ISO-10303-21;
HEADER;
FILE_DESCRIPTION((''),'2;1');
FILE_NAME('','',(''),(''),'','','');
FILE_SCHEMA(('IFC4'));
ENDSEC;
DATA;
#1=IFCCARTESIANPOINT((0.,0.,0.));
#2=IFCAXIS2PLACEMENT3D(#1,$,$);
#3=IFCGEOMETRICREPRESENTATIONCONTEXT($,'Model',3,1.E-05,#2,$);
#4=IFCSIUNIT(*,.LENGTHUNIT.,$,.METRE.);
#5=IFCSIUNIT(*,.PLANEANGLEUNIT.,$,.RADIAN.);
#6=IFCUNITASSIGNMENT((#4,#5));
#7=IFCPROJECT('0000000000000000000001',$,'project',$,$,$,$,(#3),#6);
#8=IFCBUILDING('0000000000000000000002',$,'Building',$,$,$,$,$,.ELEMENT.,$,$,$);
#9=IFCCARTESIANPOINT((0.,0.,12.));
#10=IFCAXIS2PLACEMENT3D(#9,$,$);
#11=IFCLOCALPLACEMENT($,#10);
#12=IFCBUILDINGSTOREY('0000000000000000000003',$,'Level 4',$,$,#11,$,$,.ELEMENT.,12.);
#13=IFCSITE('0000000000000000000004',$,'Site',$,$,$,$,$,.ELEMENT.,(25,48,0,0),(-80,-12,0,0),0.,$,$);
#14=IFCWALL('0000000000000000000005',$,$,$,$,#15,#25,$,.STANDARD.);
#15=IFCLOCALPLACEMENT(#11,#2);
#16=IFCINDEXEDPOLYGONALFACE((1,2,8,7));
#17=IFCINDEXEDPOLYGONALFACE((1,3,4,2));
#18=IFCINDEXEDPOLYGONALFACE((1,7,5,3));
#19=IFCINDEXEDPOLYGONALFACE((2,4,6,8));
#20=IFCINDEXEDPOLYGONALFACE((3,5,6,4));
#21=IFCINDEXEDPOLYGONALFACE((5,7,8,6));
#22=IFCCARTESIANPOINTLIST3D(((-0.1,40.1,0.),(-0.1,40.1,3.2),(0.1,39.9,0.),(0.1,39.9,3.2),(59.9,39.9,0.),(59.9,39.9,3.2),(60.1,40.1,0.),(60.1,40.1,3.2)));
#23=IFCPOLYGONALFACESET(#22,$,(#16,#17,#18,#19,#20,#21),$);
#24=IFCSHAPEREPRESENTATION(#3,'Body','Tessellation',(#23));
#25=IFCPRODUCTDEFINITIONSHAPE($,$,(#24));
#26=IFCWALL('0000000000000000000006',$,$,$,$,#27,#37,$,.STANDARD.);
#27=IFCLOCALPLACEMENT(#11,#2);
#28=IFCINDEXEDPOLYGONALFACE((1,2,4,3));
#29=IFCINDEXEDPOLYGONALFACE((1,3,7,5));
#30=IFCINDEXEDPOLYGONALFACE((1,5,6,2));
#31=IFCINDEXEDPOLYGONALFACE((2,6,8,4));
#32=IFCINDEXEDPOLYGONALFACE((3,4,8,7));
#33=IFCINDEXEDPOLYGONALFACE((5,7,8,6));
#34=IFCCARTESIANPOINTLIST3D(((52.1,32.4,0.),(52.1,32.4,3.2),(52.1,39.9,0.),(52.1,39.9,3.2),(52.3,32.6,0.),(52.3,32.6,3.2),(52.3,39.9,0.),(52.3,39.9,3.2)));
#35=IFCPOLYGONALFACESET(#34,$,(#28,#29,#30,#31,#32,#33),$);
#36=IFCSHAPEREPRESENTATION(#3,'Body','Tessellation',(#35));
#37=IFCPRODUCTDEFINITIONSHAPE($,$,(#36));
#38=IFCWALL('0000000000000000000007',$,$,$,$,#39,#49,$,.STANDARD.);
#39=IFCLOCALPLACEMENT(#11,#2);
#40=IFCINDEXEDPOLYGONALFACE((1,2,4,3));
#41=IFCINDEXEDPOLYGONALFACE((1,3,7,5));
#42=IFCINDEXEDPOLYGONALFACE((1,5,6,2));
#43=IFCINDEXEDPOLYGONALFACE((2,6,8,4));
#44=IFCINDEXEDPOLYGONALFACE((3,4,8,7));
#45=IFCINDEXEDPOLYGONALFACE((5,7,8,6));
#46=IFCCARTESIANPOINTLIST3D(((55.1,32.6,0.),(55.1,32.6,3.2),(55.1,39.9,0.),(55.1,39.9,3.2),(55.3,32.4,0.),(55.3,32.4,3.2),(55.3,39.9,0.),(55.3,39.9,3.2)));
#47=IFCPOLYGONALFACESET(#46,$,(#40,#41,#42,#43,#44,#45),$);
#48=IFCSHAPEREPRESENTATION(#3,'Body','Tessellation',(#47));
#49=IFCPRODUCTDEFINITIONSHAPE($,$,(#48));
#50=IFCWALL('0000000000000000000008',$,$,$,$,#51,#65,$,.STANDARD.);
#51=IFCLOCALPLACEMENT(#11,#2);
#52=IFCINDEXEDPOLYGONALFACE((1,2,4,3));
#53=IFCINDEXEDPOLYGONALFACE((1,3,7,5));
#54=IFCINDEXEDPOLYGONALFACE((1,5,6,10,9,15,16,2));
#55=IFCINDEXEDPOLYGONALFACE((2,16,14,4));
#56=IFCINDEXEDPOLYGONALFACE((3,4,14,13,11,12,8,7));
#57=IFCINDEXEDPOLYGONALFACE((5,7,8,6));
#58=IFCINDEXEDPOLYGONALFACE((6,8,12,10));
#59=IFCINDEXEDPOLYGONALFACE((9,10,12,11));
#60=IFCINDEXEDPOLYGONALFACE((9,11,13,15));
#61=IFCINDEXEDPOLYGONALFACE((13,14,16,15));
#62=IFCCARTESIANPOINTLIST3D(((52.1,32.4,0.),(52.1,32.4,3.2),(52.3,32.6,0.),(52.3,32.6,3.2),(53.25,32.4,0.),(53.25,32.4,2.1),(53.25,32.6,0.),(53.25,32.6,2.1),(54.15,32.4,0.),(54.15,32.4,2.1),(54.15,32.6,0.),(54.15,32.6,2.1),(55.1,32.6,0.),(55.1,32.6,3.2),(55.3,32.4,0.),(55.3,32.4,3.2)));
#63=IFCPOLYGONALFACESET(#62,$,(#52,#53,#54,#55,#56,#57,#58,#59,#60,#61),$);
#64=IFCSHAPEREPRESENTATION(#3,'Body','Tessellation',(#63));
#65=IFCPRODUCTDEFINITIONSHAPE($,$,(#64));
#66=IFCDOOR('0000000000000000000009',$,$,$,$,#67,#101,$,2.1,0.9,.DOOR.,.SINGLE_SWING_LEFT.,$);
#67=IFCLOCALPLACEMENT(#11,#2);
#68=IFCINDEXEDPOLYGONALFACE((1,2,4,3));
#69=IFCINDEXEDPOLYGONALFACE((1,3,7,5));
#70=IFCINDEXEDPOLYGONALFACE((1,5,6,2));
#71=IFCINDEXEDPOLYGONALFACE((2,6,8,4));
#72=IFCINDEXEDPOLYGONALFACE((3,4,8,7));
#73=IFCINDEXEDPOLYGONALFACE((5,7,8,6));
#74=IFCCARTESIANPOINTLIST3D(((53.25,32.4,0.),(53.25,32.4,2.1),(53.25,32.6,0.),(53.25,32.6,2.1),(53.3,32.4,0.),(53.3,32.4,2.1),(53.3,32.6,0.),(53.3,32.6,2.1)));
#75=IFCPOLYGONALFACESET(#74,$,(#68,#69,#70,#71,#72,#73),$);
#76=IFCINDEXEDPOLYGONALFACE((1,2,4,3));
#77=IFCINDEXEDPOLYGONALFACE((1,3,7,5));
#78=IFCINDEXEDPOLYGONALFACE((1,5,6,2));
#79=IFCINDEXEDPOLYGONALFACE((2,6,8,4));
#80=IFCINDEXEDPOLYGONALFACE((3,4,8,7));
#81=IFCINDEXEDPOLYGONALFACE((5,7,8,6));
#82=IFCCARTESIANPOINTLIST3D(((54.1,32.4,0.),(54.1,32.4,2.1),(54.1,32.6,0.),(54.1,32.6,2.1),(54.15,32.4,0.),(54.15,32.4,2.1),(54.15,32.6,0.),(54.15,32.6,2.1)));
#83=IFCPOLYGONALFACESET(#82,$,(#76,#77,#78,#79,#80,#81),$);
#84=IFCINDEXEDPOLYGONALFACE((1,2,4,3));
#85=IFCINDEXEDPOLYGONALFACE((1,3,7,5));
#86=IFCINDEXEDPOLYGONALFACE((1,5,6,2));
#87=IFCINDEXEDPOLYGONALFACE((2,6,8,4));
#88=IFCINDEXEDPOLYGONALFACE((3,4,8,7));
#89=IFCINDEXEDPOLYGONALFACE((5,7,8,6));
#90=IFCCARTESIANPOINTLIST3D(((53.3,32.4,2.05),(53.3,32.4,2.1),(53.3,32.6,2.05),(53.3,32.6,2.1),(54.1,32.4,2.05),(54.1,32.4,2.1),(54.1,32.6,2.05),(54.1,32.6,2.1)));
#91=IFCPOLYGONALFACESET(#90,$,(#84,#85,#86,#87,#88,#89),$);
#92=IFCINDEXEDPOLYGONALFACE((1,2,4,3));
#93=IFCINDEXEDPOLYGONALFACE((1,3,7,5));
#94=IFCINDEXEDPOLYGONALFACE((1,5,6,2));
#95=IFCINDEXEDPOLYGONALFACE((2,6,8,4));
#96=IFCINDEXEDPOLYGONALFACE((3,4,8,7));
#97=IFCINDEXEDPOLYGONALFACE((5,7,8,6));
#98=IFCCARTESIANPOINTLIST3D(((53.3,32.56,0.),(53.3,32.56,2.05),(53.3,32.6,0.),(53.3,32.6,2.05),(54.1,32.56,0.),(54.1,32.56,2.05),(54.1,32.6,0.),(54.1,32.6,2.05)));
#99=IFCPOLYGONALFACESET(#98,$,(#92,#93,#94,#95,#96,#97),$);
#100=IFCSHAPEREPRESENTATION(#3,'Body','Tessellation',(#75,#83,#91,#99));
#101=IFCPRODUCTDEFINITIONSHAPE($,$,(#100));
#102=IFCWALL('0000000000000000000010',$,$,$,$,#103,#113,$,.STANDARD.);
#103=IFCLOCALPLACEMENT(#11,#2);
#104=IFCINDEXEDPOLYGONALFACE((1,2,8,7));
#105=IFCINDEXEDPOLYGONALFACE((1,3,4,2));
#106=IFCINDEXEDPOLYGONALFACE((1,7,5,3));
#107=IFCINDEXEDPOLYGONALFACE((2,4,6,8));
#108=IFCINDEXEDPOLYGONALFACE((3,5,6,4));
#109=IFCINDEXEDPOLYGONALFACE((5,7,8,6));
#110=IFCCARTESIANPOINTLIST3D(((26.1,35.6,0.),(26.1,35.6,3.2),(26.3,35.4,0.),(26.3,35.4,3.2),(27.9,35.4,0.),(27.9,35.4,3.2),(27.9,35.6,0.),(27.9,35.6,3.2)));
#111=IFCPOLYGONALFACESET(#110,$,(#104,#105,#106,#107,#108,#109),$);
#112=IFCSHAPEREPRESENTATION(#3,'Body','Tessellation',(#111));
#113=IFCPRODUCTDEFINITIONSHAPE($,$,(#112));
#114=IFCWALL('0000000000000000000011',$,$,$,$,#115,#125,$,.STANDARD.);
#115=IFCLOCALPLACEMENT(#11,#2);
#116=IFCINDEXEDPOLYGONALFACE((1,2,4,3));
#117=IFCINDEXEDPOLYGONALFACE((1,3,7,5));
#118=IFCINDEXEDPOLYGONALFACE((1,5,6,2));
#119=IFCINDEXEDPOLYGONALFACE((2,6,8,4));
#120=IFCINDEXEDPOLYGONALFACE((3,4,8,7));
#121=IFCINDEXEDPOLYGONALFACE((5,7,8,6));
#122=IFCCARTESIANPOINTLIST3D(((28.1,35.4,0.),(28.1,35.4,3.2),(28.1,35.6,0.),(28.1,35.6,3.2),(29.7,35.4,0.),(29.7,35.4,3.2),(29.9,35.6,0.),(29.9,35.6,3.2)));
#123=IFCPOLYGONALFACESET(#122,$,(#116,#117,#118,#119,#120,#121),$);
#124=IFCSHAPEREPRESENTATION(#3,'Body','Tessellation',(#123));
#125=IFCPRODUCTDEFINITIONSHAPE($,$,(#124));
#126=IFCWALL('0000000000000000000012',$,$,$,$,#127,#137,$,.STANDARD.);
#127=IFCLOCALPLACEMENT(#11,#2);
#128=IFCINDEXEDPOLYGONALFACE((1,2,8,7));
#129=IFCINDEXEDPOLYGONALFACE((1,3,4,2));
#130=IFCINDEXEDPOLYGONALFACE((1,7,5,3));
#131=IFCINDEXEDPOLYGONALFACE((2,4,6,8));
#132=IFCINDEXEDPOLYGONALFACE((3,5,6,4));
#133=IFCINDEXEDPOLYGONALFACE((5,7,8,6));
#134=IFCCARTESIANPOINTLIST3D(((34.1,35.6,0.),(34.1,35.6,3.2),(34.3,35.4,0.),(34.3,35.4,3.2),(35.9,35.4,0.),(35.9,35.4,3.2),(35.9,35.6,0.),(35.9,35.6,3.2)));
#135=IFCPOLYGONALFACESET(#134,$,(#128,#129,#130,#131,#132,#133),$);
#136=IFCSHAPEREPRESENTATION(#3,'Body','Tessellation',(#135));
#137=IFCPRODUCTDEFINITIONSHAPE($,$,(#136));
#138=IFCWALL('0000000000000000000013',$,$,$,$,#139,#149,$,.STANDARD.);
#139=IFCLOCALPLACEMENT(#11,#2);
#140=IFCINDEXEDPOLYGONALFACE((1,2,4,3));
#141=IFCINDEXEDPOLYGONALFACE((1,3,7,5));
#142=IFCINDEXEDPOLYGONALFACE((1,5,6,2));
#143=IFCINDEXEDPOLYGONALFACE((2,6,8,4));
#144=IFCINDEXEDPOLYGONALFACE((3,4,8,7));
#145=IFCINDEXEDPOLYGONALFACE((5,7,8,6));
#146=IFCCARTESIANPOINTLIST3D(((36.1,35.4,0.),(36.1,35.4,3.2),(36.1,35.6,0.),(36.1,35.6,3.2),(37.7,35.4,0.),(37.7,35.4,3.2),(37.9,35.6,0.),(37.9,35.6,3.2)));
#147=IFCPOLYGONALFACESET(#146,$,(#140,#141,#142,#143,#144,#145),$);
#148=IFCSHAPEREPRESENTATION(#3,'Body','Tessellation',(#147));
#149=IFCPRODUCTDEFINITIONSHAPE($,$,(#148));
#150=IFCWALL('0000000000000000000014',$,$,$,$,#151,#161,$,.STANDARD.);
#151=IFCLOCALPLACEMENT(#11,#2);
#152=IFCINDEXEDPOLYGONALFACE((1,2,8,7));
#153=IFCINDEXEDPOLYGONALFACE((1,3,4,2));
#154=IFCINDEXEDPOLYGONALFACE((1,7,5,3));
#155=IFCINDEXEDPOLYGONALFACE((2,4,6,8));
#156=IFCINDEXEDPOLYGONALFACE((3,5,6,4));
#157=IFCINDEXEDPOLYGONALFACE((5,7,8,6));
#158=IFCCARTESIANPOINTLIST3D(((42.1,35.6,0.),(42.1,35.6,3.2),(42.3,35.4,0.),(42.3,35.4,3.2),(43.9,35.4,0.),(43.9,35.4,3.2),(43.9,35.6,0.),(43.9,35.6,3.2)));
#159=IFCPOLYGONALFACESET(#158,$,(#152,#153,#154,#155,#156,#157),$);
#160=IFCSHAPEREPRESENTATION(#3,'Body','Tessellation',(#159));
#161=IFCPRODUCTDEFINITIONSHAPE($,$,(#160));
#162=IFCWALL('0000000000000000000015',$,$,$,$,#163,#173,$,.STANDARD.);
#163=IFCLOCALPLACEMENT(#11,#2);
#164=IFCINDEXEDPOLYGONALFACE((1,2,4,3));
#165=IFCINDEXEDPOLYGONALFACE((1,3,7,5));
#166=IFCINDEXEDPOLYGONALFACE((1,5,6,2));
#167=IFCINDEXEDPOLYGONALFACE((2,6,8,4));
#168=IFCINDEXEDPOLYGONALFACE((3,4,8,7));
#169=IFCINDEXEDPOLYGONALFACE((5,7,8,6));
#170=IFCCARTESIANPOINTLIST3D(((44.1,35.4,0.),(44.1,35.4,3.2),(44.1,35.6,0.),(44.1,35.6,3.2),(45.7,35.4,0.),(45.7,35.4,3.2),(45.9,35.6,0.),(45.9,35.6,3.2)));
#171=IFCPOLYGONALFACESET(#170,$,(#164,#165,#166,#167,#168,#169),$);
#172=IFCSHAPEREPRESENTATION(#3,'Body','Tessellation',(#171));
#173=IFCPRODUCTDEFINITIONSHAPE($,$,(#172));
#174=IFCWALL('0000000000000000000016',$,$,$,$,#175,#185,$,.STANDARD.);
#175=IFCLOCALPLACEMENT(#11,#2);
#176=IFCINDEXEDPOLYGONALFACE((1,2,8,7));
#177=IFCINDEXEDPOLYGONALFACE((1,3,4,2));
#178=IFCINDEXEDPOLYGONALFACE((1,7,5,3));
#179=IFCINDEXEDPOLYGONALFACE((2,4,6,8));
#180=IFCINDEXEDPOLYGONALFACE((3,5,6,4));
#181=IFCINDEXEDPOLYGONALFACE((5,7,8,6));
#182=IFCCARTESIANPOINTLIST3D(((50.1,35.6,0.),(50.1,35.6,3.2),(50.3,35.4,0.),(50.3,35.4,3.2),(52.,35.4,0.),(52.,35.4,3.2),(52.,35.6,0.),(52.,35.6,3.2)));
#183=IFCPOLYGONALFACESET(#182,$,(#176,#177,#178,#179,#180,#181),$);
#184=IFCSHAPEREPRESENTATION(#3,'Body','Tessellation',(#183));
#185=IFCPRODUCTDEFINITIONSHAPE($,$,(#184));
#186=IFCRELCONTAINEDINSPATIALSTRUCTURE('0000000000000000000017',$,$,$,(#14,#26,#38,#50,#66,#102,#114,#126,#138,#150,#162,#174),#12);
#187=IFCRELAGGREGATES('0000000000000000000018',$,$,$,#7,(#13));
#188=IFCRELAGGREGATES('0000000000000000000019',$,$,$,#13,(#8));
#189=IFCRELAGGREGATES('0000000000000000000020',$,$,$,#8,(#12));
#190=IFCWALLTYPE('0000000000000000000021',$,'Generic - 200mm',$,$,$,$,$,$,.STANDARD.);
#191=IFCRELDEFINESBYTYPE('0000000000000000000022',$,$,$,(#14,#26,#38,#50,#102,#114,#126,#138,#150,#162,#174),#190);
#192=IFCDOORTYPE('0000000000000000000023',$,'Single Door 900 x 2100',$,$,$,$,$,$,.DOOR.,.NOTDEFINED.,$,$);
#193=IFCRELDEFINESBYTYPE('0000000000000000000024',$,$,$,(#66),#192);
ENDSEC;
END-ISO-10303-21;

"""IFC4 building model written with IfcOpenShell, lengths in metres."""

from ifc_helpers import new_model, si_unit, frame, frame_2d, origin, origin_with_axes, origin_2d, place, context, project, spatial, polyline, rectangle, outline, extrude, type_object, element, fill, save


model = new_model("IFC4")

# Units and contexts
model_context = context("Model", 3, precision=1e-05, world=origin())
ifc_project = project(units=[si_unit("LENGTHUNIT", "METRE"), si_unit("PLANEANGLEUNIT", "RADIAN")], contexts=[model_context])

# Site, building, storey
site = spatial("IfcSite", under=ifc_project, Name="Site", CompositionType="ELEMENT", RefLatitude=(25, 48, 0, 0), RefLongitude=(-80, -12, 0, 0), RefElevation=0.0)
building = spatial("IfcBuilding", under=site, Name="Building", CompositionType="ELEMENT")
storey_placement = place(None, frame((0.0, 0.0, 12.0)))
storey = spatial("IfcBuildingStorey", under=building, at=storey_placement, Name="Level 4", CompositionType="ELEMENT", Elevation=12.0)

# Walls
wall_type = type_object("IfcWallType", Name="Generic - 200mm", PredefinedType="STANDARD")
wall_1_placement = place(None, frame((60.0, 40.0, 12.0), z_axis=(0.0, 0.0, 1.0), x_axis=(-1.0, 0.0, 0.0)))
element("IfcWall", 1, at=wall_1_placement, inside=storey, type_object=wall_type, PredefinedType="STANDARD", context=model_context, shape_type="SweptSolid", body=[
    extrude(outline(polyline([(-0.1, -0.1), (60.1, -0.1), (59.9, 0.1), (0.1, 0.1), (-0.1, -0.1)])), origin(), (0.0, 0.0, 1.0), 3.2),
])
wall_2_placement = place(None, frame((52.2, 32.5, 12.0), z_axis=(0.0, 0.0, 1.0), x_axis=(0.0, 1.0, 0.0)))
element("IfcWall", 2, at=wall_2_placement, inside=storey, type_object=wall_type, PredefinedType="STANDARD", context=model_context, shape_type="SweptSolid", body=[
    extrude(outline(polyline([(0.1, -0.1), (7.4, -0.1), (7.4, 0.1), (-0.1, 0.1), (0.1, -0.1)])), origin(), (0.0, 0.0, 1.0), 3.2),
])
wall_3_placement = place(None, frame((55.2, 32.5, 12.0), z_axis=(0.0, 0.0, 1.0), x_axis=(0.0, 1.0, 0.0)))
element("IfcWall", 3, at=wall_3_placement, inside=storey, type_object=wall_type, PredefinedType="STANDARD", context=model_context, shape_type="SweptSolid", body=[
    extrude(outline(polyline([(-0.1, -0.1), (7.4, -0.1), (7.4, 0.1), (0.1, 0.1), (-0.1, -0.1)])), origin(), (0.0, 0.0, 1.0), 3.2),
])

# Wall, opening, door
wall_4_placement = place(None, frame((52.2, 32.5, 12.0), z_axis=(0.0, 0.0, 1.0), x_axis=(1.0, 0.0, 0.0)))
wall_4 = element("IfcWall", 4, at=wall_4_placement, inside=storey, type_object=wall_type, PredefinedType="STANDARD", context=model_context, shape_type="SweptSolid", body=[
    extrude(outline(polyline([(-0.1, -0.1), (3.1, -0.1), (2.9, 0.1), (0.1, 0.1), (-0.1, -0.1)])), origin(), (0.0, 0.0, 1.0), 3.2),
])
opening_placement = place(wall_4_placement, frame((1.5, 0.0, 0.0), z_axis=(0.0, 0.0, 1.0), x_axis=(1.0, 0.0, 0.0)))
opening = element("IfcOpeningElement", 5, at=opening_placement, cuts=wall_4, PredefinedType="OPENING", context=model_context, shape_type="SweptSolid", body=[
    extrude(rectangle(XDim=0.9, YDim=0.202, at=origin_2d()), origin(), (0.0, 0.0, 1.0), 2.1),
])
door_type = type_object("IfcDoorType", Name="Single Door 900 x 2100", OperationType="NOTDEFINED", PredefinedType="DOOR")
door_placement = place(opening_placement, origin_with_axes())
door = element("IfcDoor", 6, at=door_placement, inside=storey, type_object=door_type, OperationType="SINGLE_SWING_LEFT", OverallHeight=2.1, OverallWidth=0.9, PredefinedType="DOOR", context=model_context, shape_type="SweptSolid", body=[
    extrude(rectangle(XDim=0.05, YDim=0.2, at=frame_2d((-0.425, 0.0))), origin(), (0.0, 0.0, 1.0), 2.1),
    extrude(rectangle(XDim=0.05, YDim=0.2, at=frame_2d((0.425, 0.0))), origin(), (0.0, 0.0, 1.0), 2.1),
    extrude(rectangle(XDim=0.8, YDim=0.2, at=origin_2d()), frame((0.0, 0.0, 2.05)), (0.0, 0.0, 1.0), 0.05),
    extrude(rectangle(XDim=0.8, YDim=0.04, at=frame_2d((0.0, 0.08))), origin(), (0.0, 0.0, 1.0), 2.05),
])
fill(opening, door)

# Walls
wall_5_placement = place(None, frame((26.2, 35.5, 12.0), z_axis=(0.0, 0.0, 1.0), x_axis=(1.0, 0.0, 0.0)))
element("IfcWall", 7, at=wall_5_placement, inside=storey, type_object=wall_type, PredefinedType="STANDARD", context=model_context, shape_type="SweptSolid", body=[
    extrude(outline(polyline([(0.1, -0.1), (1.7, -0.1), (1.7, 0.1), (-0.1, 0.1), (0.1, -0.1)])), origin(), (0.0, 0.0, 1.0), 3.2),
])
wall_6_placement = place(None, frame((29.8, 35.5, 12.0), z_axis=(0.0, 0.0, 1.0), x_axis=(-1.0, 0.0, 0.0)))
element("IfcWall", 8, at=wall_6_placement, inside=storey, type_object=wall_type, PredefinedType="STANDARD", context=model_context, shape_type="SweptSolid", body=[
    extrude(outline(polyline([(-0.1, -0.1), (1.7, -0.1), (1.7, 0.1), (0.1, 0.1), (-0.1, -0.1)])), origin(), (0.0, 0.0, 1.0), 3.2),
])
wall_7_placement = place(None, frame((34.2, 35.5, 12.0), z_axis=(0.0, 0.0, 1.0), x_axis=(1.0, 0.0, 0.0)))
element("IfcWall", 9, at=wall_7_placement, inside=storey, type_object=wall_type, PredefinedType="STANDARD", context=model_context, shape_type="SweptSolid", body=[
    extrude(outline(polyline([(0.1, -0.1), (1.7, -0.1), (1.7, 0.1), (-0.1, 0.1), (0.1, -0.1)])), origin(), (0.0, 0.0, 1.0), 3.2),
])
wall_8_placement = place(None, frame((37.8, 35.5, 12.0), z_axis=(0.0, 0.0, 1.0), x_axis=(-1.0, 0.0, 0.0)))
element("IfcWall", 10, at=wall_8_placement, inside=storey, type_object=wall_type, PredefinedType="STANDARD", context=model_context, shape_type="SweptSolid", body=[
    extrude(outline(polyline([(-0.1, -0.1), (1.7, -0.1), (1.7, 0.1), (0.1, 0.1), (-0.1, -0.1)])), origin(), (0.0, 0.0, 1.0), 3.2),
])
wall_9_placement = place(None, frame((42.2, 35.5, 12.0), z_axis=(0.0, 0.0, 1.0), x_axis=(1.0, 0.0, 0.0)))
element("IfcWall", 11, at=wall_9_placement, inside=storey, type_object=wall_type, PredefinedType="STANDARD", context=model_context, shape_type="SweptSolid", body=[
    extrude(outline(polyline([(0.1, -0.1), (1.7, -0.1), (1.7, 0.1), (-0.1, 0.1), (0.1, -0.1)])), origin(), (0.0, 0.0, 1.0), 3.2),
])
wall_10_placement = place(None, frame((45.8, 35.5, 12.0), z_axis=(0.0, 0.0, 1.0), x_axis=(-1.0, 0.0, 0.0)))
element("IfcWall", 12, at=wall_10_placement, inside=storey, type_object=wall_type, PredefinedType="STANDARD", context=model_context, shape_type="SweptSolid", body=[
    extrude(outline(polyline([(-0.1, -0.1), (1.7, -0.1), (1.7, 0.1), (0.1, 0.1), (-0.1, -0.1)])), origin(), (0.0, 0.0, 1.0), 3.2),
])
wall_11_placement = place(None, frame((50.2, 35.5, 12.0), z_axis=(0.0, 0.0, 1.0), x_axis=(1.0, 0.0, 0.0)))
element("IfcWall", 13, at=wall_11_placement, inside=storey, type_object=wall_type, PredefinedType="STANDARD", context=model_context, shape_type="SweptSolid", body=[
    extrude(outline(polyline([(0.1, -0.1), (1.8, -0.1), (1.8, 0.1), (-0.1, 0.1), (0.1, -0.1)])), origin(), (0.0, 0.0, 1.0), 3.2),
])

save(model, "model.ifc")
